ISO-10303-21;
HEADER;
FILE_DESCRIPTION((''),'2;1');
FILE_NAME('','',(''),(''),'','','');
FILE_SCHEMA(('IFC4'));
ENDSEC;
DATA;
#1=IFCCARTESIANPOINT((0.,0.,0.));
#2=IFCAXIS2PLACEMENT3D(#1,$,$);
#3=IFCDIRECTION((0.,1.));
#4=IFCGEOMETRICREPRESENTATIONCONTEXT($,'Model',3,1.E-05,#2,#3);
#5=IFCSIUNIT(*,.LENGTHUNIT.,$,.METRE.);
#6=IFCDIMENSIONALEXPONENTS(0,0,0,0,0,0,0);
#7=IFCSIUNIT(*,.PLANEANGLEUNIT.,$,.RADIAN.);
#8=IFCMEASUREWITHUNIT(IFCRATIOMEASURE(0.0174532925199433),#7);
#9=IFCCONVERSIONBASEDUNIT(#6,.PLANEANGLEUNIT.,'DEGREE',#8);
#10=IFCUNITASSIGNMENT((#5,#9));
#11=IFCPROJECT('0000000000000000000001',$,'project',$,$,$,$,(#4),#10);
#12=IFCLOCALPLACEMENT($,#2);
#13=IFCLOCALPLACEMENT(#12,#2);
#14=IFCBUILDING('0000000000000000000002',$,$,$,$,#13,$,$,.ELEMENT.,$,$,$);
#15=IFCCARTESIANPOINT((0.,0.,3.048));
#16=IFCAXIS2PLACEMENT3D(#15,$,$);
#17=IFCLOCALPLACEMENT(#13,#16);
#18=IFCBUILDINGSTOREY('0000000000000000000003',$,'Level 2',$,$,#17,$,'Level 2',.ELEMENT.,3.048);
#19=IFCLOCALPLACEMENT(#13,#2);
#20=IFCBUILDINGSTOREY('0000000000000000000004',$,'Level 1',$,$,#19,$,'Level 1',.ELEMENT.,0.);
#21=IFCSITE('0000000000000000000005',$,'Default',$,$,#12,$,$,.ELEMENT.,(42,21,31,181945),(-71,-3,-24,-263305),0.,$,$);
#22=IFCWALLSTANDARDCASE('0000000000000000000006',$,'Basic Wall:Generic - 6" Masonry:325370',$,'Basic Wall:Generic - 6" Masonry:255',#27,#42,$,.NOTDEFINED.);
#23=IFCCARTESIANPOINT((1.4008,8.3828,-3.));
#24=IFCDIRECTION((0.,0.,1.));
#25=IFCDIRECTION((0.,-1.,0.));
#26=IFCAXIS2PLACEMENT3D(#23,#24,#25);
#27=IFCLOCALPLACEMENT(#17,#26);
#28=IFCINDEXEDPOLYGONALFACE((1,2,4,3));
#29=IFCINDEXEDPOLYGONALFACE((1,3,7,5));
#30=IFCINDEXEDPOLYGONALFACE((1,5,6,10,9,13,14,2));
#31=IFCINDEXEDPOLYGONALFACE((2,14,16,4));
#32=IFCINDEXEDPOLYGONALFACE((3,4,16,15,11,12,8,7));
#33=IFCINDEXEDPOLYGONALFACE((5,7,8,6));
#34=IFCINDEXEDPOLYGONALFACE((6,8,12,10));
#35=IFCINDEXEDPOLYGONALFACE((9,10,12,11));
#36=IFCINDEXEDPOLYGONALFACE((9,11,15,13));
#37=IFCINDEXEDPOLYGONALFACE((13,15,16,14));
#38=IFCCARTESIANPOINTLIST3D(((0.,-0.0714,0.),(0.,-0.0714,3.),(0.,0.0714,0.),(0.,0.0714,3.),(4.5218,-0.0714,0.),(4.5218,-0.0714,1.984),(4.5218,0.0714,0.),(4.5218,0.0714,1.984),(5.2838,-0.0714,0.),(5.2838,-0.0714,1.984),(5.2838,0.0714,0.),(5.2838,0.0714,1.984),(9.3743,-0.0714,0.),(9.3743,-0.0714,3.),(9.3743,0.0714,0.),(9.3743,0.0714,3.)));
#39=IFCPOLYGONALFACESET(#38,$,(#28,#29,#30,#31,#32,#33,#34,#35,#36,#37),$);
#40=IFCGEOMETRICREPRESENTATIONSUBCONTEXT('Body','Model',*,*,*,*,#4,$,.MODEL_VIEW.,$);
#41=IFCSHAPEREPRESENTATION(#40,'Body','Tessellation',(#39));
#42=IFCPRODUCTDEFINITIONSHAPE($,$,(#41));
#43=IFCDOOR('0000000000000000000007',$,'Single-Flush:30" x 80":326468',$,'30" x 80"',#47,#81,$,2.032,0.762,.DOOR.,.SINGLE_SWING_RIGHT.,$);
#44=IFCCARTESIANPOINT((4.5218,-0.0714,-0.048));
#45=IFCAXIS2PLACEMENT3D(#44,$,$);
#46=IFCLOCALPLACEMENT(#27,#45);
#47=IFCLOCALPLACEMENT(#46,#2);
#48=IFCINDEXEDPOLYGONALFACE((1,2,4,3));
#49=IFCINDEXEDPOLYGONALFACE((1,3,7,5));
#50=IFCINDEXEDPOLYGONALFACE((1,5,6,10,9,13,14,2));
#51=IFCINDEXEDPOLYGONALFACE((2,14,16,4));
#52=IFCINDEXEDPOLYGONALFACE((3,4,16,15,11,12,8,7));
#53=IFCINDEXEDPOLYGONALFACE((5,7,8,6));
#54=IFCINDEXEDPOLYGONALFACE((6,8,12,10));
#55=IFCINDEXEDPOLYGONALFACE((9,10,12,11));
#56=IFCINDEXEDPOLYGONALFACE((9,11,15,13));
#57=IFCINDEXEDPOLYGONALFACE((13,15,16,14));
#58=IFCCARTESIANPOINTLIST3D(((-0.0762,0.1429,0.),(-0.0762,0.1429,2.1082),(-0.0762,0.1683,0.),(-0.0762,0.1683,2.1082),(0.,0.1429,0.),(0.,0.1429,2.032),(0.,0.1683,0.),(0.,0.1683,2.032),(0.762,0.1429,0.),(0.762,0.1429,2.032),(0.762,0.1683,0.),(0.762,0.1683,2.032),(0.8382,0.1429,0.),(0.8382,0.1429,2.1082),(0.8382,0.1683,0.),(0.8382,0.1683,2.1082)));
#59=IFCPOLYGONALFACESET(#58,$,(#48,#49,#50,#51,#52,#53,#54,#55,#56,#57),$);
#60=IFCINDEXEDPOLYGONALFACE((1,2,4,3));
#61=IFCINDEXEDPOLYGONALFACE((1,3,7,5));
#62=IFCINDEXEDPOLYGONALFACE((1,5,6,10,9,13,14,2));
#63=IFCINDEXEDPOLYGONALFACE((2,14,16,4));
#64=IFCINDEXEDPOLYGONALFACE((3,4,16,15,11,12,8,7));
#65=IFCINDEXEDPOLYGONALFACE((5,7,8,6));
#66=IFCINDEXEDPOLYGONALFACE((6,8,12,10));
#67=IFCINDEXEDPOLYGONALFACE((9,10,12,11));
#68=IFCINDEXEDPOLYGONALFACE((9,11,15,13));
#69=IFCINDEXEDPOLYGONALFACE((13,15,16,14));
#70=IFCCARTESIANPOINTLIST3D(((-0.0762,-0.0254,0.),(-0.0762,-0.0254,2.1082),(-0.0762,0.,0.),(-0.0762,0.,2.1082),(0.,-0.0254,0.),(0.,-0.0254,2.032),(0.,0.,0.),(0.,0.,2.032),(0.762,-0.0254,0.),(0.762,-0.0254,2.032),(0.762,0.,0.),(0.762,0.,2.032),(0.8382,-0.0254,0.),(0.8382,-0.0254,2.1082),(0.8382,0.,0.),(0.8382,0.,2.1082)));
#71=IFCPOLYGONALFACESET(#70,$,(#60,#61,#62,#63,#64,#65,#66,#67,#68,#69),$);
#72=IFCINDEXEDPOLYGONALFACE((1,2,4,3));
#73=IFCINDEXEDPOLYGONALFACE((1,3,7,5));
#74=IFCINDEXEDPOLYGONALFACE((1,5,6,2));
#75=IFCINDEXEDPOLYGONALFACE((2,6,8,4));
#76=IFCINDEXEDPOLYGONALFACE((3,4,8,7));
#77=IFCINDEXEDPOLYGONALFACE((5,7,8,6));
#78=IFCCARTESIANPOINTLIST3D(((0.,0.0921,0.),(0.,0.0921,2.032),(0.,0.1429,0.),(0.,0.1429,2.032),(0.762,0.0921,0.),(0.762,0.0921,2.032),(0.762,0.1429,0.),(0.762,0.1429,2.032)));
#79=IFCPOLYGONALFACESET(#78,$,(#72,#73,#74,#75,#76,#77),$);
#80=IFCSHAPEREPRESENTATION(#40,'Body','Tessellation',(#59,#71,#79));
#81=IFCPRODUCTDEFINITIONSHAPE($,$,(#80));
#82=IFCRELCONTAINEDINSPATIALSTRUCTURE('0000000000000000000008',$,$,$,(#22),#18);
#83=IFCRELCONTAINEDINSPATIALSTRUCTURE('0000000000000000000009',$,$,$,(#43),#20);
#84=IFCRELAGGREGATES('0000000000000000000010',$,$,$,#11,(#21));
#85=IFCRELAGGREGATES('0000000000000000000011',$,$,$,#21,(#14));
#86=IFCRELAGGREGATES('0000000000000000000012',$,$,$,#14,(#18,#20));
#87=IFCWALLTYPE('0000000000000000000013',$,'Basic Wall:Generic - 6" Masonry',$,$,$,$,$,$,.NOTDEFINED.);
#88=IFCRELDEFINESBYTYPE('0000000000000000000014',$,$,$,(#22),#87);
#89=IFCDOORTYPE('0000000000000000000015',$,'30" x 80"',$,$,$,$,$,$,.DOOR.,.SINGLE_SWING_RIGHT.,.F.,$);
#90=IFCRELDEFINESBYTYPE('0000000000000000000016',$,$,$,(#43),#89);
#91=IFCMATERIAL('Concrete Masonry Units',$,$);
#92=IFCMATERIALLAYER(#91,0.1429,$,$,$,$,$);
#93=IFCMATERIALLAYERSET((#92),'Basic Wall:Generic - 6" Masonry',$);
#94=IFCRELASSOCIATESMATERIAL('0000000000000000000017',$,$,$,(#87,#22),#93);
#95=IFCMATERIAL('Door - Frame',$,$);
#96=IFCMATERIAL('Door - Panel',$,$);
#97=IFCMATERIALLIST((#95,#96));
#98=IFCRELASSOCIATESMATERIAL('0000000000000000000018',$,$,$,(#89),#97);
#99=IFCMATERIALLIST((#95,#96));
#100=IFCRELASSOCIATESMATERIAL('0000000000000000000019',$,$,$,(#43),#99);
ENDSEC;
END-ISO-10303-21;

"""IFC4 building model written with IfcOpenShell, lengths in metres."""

from ifc_helpers import new_model, entity, si_unit, converted_unit, direction, frame, frame_2d, origin, place, context, subcontext, project, spatial, polyline, rectangle, outline, extrude, source, transform, mapped, material, material_list, layer, layer_set, layer_usage, type_object, type_shapes, element, fill, save


model = new_model("IFC4")

# Units and contexts
model_context = context("Model", 3, precision=1e-05, world=origin(), true_north=direction((0.0, 1.0)))
body_context = subcontext(model_context, "Body", "Model", "MODEL_VIEW")
ifc_project = project(units=[si_unit("LENGTHUNIT", "METRE"), converted_unit("PLANEANGLEUNIT", "DEGREE", entity("IfcRatioMeasure", 0.0174532925199433), si_unit("PLANEANGLEUNIT", "RADIAN"), dimensions=[0, 0, 0, 0, 0, 0, 0])], contexts=[model_context])

# Site, building, storey
site_placement = place(None, origin())
site = spatial("IfcSite", under=ifc_project, at=site_placement, Name="Default", CompositionType="ELEMENT", RefLatitude=(42, 21, 31, 181945), RefLongitude=(-71, -3, -24, -263305), RefElevation=0.0)
building_placement = place(site_placement, origin())
building = spatial("IfcBuilding", under=site, at=building_placement, CompositionType="ELEMENT")
storey_1_placement = place(building_placement, frame((0.0, 0.0, 3.048)))
storey_1 = spatial("IfcBuildingStorey", under=building, at=storey_1_placement, Name="Level 2", LongName="Level 2", CompositionType="ELEMENT", Elevation=3.048)

# Shared definitions
ifc_material_1 = material(Name="Concrete Masonry Units")
ifc_layer = layer(ifc_material_1, 0.1429)
ifc_layer_set = layer_set([ifc_layer], Name="Basic Wall:Generic - 6\" Masonry")
wall_type = type_object("IfcWallType", Name="Basic Wall:Generic - 6\" Masonry", PredefinedType="NOTDEFINED", material=ifc_layer_set)

# Shared definitions
storey_2_placement = place(building_placement, origin())
storey_2 = spatial("IfcBuildingStorey", under=building, at=storey_2_placement, Name="Level 1", LongName="Level 1", CompositionType="ELEMENT", Elevation=0.0)

# Shared definitions
ifc_material_2 = material(Name="Door - Frame")
ifc_material_3 = material(Name="Door - Panel")
ifc_material_list_1 = material_list([ifc_material_2, ifc_material_3])
door_type = type_object("IfcDoorType", Name="30\" x 80\"", OperationType="SINGLE_SWING_RIGHT", ParameterTakesPrecedence=False, PredefinedType="DOOR", material=ifc_material_list_1)
shared_shape_1 = source(origin(), body_context, "Body", "SweptSolid", [
    extrude(outline(polyline([(-0.4572, -1.0732), (0.4572, -1.0732), (0.4572, 1.0351), (0.381, 1.0351), (0.381, -0.997), (-0.381, -0.997), (-0.381, 1.0351), (-0.4572, 1.0351), (-0.4572, -1.0732)])), frame((0.381, 0.1429, 1.0351), z_axis=(0.0, 1.0, 0.0), x_axis=(1.0, 0.0, 0.0)), (0.0, 0.0, 1.0), 0.0254),
    extrude(outline(polyline([(-1.0732, -0.4572), (1.0351, -0.4572), (1.0351, -0.381), (-0.997, -0.381), (-0.997, 0.381), (1.0351, 0.381), (1.0351, 0.4572), (-1.0732, 0.4572), (-1.0732, -0.4572)])), frame((0.381, -0.0254, 1.0351), z_axis=(0.0, 1.0, 0.0), x_axis=(0.0, 0.0, -1.0)), (0.0, 0.0, 1.0), 0.0254),
    extrude(rectangle(XDim=0.0508, YDim=0.762, at=frame_2d((0.0, 0.0), x_axis=(1.0, 0.0))), frame((0.381, 0.1175, 0.0), z_axis=(0.0, 0.0, 1.0), x_axis=(0.0, 1.0, 0.0)), (0.0, 0.0, 1.0), 2.032),
])
type_shapes(door_type, [shared_shape_1])

# Wall, opening, door
ifc_layer_usage_1 = layer_usage(ifc_layer_set, "AXIS2", "NEGATIVE", 0.0714)
wall_1_placement = place(storey_1_placement, frame((1.4008, 8.3828, -3.0), z_axis=(0.0, 0.0, 1.0), x_axis=(0.0, -1.0, 0.0)))
wall_1 = element("IfcWallStandardCase", 1, at=wall_1_placement, inside=storey_1, type_object=wall_type, material=ifc_layer_usage_1, Name="Basic Wall:Generic - 6\" Masonry:325370", ObjectType="Basic Wall:Generic - 6\" Masonry:255", PredefinedType="NOTDEFINED", context=body_context, shape_type="SweptSolid", body=[
    extrude(rectangle(XDim=9.3743, YDim=0.1429, at=frame_2d((4.6871, 0.0), x_axis=(-1.0, 0.0))), origin(), (0.0, 0.0, 1.0), 3.0),
])
opening_1_placement = place(wall_1_placement, frame((4.5218, -0.0714, -0.048)))
opening_1 = element("IfcOpeningElement", 2, at=opening_1_placement, cuts=wall_1, ObjectType="Opening", PredefinedType="OPENING", context=body_context, shape_type="SweptSolid", body=[
    extrude(rectangle(XDim=0.762, YDim=2.032, at=frame_2d((1.016, 0.381), x_axis=(0.0, 1.0))), frame((0.0, 0.0, 0.0), z_axis=(0.0, 1.0, 0.0), x_axis=(0.0, 0.0, 1.0)), (0.0, 0.0, 1.0), 0.1429),
])
ifc_material_list_2 = material_list([ifc_material_2, ifc_material_3])
door_1_placement = place(opening_1_placement, origin())
door_1 = element("IfcDoor", 3, at=door_1_placement, inside=storey_2, type_object=door_type, material=ifc_material_list_2, Name="Single-Flush:30\" x 80\":326468", ObjectType="30\" x 80\"", OperationType="SINGLE_SWING_RIGHT", OverallHeight=2.032, OverallWidth=0.762, PredefinedType="DOOR", context=body_context, shape_type="MappedRepresentation", body=[
    mapped(shared_shape_1, transform((0.0, 0.0, 0.0), scale=1.0)),
])
fill(opening_1, door_1)

save(model, "model.ifc")
